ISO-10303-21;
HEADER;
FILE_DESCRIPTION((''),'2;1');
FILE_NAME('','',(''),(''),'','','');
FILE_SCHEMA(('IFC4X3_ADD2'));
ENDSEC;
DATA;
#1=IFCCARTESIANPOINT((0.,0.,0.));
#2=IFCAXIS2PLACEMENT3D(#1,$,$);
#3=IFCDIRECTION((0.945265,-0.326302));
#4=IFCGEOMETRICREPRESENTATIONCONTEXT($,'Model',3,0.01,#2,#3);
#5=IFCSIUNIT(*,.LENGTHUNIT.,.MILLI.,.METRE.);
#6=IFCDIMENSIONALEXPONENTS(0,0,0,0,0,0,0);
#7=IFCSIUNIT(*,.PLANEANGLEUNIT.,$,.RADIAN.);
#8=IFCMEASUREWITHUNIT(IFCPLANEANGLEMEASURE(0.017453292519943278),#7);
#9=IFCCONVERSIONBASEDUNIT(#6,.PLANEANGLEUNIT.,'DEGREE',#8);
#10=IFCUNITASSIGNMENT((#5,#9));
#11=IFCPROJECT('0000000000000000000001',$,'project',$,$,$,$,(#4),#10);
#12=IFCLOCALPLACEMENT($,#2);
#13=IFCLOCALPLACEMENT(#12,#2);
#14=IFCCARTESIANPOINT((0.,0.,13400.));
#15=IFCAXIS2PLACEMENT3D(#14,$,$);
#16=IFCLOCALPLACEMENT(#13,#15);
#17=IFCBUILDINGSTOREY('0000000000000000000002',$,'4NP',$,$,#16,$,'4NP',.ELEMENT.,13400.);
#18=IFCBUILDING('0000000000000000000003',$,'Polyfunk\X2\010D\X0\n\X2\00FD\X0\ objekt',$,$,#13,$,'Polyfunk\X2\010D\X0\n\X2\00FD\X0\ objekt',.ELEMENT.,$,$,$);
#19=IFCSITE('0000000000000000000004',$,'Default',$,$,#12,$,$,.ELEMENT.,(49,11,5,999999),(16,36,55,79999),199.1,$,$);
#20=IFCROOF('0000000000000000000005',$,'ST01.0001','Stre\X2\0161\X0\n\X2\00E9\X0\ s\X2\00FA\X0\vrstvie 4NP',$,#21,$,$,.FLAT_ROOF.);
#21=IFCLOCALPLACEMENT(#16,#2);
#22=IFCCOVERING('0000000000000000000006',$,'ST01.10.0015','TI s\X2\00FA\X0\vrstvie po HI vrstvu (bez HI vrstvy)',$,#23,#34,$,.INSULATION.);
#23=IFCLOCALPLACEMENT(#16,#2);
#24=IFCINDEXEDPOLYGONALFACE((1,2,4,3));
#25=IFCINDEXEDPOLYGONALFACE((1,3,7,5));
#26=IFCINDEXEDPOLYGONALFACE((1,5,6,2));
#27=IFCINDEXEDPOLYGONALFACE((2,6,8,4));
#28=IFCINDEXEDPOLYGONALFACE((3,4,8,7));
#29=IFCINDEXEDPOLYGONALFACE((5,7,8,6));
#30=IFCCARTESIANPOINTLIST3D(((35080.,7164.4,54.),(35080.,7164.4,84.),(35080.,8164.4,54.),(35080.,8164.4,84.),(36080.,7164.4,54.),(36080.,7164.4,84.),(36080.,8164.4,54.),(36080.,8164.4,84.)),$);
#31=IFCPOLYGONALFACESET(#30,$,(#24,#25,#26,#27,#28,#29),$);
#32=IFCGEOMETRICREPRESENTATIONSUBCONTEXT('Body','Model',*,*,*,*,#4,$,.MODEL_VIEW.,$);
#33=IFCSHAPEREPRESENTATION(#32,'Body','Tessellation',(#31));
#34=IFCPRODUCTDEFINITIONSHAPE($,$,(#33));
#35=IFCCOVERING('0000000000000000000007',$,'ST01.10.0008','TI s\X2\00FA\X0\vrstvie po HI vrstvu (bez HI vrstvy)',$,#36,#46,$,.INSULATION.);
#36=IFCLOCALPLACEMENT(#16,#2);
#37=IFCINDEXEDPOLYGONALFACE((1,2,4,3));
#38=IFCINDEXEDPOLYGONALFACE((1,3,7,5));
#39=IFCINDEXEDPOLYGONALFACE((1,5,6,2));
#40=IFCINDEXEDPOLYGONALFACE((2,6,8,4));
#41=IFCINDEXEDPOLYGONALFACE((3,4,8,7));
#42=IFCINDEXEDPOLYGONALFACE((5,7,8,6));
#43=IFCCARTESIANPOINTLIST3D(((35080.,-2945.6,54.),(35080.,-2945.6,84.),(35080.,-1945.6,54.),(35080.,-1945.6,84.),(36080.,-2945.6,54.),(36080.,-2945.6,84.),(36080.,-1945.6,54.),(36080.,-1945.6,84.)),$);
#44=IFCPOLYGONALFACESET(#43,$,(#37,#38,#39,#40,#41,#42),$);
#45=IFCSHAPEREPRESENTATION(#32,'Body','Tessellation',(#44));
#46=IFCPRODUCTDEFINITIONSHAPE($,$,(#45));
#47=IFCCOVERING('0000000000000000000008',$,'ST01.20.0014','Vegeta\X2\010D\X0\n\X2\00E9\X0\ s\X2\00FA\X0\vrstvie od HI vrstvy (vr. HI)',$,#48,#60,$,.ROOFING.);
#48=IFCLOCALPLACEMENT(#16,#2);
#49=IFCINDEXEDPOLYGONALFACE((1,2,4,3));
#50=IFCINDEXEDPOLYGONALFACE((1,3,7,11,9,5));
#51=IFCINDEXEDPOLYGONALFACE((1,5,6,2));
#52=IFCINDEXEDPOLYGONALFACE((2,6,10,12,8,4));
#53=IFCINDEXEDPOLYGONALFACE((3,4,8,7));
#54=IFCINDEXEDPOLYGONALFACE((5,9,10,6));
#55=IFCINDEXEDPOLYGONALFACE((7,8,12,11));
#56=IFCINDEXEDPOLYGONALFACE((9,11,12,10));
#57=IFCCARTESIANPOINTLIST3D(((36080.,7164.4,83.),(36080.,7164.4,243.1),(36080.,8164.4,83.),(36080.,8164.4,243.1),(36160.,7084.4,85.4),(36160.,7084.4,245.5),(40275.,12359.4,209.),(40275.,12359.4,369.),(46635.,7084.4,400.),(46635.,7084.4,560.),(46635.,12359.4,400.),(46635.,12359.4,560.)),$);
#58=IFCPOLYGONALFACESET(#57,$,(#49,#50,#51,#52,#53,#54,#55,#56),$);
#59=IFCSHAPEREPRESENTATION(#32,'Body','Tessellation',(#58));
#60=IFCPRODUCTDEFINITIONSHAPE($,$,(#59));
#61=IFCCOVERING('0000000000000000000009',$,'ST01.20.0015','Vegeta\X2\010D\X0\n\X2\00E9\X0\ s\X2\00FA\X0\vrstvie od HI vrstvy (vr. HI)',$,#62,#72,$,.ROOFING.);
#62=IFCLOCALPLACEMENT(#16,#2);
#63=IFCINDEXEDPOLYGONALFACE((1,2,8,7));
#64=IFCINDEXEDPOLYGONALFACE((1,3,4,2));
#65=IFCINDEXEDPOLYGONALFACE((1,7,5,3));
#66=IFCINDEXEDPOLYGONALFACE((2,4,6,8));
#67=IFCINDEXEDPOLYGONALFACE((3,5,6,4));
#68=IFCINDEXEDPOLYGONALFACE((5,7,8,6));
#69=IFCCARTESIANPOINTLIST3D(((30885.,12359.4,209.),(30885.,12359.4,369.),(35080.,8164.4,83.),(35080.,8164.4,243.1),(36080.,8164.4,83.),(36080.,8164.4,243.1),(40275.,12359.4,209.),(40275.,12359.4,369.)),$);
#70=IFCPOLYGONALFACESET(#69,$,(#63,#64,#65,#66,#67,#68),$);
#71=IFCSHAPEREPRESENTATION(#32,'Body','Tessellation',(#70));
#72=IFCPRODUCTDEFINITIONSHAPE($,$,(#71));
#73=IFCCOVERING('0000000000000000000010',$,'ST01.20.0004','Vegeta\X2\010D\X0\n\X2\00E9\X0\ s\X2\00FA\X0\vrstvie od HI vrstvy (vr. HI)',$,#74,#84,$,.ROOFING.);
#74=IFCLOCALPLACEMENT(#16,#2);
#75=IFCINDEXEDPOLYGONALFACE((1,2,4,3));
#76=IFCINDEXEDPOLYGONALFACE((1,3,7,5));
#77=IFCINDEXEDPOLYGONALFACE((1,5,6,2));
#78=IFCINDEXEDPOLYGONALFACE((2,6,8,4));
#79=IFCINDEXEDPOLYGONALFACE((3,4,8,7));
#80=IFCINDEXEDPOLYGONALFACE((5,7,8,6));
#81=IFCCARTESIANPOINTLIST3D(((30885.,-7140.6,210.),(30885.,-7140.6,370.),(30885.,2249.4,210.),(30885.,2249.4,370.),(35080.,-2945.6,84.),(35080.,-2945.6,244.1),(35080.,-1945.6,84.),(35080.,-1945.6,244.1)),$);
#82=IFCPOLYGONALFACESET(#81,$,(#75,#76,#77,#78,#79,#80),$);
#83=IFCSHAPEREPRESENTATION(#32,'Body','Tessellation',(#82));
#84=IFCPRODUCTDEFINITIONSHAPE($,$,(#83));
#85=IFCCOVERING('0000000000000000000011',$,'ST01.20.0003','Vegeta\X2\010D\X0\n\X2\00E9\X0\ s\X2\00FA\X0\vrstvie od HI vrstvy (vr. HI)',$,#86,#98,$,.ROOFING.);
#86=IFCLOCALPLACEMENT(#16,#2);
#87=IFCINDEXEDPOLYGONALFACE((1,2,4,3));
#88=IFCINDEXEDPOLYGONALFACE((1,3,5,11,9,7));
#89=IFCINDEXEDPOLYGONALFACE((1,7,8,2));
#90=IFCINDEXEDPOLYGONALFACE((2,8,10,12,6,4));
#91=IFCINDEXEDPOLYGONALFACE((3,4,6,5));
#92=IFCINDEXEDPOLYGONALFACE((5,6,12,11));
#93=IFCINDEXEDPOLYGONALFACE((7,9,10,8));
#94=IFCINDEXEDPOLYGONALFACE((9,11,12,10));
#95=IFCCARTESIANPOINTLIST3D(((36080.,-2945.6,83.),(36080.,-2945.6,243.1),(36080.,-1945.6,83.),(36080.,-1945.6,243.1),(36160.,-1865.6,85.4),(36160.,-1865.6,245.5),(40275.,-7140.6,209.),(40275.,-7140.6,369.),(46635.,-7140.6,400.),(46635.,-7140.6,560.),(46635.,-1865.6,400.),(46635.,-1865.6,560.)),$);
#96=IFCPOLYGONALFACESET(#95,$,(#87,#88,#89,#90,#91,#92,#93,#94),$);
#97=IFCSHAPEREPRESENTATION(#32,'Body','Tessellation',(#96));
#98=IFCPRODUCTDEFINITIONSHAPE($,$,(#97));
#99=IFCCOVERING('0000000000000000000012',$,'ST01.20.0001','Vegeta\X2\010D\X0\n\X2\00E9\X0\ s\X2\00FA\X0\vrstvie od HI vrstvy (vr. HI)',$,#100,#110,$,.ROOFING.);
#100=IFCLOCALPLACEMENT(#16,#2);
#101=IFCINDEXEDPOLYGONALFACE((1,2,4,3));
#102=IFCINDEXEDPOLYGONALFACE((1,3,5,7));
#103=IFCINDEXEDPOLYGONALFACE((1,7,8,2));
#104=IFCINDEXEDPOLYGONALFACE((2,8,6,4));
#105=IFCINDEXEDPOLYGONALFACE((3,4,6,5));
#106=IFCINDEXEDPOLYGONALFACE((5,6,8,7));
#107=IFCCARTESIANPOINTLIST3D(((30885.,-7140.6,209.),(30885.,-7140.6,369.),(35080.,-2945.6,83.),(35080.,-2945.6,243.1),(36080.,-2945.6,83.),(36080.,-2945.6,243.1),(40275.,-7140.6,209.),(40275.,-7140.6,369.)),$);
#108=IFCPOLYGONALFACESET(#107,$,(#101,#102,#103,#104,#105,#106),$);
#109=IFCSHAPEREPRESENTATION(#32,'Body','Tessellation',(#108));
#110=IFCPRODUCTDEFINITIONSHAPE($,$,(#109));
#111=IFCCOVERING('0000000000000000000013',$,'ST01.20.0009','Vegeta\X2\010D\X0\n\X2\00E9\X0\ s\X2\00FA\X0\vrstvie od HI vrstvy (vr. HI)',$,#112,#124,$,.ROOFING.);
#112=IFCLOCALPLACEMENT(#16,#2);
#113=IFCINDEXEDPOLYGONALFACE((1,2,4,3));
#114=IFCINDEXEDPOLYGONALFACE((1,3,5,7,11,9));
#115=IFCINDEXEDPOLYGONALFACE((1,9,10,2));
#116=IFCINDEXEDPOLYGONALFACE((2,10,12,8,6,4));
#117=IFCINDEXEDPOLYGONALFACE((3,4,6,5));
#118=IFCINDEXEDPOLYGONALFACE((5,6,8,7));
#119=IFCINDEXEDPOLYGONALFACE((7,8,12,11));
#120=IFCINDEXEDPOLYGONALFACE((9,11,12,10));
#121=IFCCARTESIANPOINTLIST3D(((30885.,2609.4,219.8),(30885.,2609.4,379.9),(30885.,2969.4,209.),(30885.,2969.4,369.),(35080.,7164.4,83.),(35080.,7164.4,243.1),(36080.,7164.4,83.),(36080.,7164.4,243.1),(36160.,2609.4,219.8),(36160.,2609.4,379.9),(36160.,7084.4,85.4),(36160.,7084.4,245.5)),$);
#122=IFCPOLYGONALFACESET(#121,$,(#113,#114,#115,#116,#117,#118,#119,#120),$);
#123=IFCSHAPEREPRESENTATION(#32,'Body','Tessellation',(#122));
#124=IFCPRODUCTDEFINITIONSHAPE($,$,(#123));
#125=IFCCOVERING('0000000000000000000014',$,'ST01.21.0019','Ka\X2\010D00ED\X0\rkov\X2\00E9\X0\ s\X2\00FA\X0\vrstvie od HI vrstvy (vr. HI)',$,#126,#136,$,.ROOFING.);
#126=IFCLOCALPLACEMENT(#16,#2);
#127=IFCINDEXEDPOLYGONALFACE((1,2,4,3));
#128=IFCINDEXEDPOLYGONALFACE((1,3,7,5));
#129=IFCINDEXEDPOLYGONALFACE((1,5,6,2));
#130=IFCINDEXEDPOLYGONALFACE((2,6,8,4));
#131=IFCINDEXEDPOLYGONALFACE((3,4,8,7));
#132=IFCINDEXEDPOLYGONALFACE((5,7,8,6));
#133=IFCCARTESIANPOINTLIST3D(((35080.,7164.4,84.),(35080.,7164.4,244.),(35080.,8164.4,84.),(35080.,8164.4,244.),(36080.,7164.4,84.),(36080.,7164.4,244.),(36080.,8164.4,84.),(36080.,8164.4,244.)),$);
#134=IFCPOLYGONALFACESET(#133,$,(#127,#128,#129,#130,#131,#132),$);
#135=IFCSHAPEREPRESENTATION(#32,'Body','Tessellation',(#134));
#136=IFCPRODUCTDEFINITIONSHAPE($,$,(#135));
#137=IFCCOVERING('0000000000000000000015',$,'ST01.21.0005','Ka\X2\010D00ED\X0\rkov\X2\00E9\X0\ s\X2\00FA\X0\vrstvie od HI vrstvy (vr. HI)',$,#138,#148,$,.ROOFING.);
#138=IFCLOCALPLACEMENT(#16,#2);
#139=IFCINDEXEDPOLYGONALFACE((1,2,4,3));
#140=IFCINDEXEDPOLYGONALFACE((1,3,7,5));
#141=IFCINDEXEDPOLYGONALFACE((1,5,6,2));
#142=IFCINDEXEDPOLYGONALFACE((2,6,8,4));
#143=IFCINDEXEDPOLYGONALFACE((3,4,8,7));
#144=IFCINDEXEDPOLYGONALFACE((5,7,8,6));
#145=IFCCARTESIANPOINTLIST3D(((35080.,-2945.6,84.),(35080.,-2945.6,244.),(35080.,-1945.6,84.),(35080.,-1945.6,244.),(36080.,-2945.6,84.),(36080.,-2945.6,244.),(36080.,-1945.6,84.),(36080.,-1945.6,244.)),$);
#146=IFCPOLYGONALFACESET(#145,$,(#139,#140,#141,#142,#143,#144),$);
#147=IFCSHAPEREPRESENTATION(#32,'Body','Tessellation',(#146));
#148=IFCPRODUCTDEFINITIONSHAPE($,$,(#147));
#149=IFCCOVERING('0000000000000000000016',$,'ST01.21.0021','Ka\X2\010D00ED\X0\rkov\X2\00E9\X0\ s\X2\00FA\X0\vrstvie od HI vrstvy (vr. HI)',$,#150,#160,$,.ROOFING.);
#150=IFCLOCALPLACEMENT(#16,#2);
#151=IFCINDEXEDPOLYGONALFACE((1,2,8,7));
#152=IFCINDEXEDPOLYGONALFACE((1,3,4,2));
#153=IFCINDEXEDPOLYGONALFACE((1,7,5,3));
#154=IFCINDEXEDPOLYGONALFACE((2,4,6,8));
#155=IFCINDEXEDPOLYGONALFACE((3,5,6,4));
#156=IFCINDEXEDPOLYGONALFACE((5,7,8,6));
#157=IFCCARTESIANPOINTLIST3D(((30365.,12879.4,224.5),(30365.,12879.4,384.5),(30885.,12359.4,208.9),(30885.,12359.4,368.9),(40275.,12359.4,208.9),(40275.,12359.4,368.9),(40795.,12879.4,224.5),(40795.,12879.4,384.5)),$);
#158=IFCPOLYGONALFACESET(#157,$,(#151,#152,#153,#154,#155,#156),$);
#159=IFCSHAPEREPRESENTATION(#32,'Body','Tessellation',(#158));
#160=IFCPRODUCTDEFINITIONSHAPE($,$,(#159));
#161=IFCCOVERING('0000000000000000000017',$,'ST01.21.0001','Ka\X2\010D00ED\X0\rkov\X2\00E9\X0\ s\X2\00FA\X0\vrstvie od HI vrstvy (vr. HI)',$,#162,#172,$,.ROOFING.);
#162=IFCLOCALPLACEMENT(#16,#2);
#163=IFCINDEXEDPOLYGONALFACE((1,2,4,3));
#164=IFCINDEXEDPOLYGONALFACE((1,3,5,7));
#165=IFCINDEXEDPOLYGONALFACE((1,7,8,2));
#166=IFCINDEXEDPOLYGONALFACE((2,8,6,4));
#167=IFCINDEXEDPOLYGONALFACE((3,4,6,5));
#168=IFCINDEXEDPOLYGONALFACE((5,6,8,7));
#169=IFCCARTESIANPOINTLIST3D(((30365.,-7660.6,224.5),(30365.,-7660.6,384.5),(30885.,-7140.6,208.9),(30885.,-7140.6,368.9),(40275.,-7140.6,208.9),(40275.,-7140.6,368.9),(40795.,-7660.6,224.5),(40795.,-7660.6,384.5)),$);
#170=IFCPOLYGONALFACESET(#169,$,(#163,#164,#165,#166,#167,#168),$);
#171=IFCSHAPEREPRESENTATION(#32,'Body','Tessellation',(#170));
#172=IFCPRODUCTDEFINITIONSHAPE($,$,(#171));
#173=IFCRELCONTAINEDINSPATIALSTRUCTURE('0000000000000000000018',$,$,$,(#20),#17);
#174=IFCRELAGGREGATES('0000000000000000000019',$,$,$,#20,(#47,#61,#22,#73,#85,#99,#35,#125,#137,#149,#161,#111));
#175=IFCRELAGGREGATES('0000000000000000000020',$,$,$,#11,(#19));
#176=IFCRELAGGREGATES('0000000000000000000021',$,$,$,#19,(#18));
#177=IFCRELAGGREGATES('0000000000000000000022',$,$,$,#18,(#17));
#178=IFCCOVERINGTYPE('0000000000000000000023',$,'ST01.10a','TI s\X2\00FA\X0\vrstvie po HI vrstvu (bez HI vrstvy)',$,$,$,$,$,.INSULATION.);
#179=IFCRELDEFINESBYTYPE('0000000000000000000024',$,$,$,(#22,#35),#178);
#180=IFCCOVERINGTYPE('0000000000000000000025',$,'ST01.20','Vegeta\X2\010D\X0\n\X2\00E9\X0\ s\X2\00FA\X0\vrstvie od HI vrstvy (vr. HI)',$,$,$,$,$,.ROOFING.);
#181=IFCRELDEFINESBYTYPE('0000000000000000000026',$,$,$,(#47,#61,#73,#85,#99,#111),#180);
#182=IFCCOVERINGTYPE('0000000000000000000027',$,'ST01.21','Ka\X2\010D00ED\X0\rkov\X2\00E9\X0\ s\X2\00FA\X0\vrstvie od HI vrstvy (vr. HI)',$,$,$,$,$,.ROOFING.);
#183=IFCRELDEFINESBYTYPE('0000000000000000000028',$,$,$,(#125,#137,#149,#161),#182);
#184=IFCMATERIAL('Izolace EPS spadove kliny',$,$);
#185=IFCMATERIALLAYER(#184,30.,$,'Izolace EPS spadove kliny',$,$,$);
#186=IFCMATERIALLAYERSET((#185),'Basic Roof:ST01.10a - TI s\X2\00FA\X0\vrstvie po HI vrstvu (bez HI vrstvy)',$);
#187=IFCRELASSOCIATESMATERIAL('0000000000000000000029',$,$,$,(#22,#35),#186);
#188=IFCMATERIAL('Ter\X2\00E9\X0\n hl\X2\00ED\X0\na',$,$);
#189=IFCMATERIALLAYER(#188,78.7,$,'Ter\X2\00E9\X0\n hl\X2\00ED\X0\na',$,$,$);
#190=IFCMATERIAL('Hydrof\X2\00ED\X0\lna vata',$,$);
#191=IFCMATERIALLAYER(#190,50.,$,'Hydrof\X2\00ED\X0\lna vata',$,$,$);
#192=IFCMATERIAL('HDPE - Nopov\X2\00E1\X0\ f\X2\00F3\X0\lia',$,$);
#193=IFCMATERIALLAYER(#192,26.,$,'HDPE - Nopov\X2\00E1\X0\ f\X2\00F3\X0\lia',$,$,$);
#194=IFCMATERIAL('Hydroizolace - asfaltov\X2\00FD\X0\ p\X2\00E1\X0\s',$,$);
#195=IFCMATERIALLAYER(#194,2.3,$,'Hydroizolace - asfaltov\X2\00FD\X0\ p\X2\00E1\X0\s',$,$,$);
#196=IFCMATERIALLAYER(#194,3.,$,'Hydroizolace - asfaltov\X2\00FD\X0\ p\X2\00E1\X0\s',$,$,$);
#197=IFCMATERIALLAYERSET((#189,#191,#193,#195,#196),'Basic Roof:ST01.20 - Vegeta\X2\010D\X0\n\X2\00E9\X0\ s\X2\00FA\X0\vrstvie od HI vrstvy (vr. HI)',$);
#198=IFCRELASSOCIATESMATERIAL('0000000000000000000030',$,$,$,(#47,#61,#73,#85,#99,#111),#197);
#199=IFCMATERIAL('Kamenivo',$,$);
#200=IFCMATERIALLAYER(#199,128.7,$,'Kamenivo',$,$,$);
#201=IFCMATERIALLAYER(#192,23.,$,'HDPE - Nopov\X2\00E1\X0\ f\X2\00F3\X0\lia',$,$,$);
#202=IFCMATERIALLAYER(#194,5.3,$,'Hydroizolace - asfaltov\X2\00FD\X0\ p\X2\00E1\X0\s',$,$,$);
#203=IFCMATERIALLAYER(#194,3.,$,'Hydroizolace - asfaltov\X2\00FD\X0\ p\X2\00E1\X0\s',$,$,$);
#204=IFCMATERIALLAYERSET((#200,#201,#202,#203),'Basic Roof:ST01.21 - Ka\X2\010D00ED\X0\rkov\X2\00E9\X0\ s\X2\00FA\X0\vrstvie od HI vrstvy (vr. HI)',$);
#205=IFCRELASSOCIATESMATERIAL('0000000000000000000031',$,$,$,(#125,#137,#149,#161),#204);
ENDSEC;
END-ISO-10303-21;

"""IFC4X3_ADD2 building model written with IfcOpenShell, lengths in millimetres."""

from ifc_helpers import new_model, entity, si_unit, converted_unit, direction, frame, frame_2d, origin, origin_2d_with_axis, place, context, subcontext, project, spatial, polyline, rectangle, outline, extrude, material, layer, layer_set, type_object, element, aggregate, save


model = new_model("IFC4X3_ADD2")

# Units and contexts
model_context = context("Model", 3, precision=0.01, world=origin(), true_north=direction((0.945265, -0.326302)))
body_context = subcontext(model_context, "Body", "Model", "MODEL_VIEW")
ifc_project = project(units=[si_unit("LENGTHUNIT", "METRE", prefix="MILLI"), converted_unit("PLANEANGLEUNIT", "DEGREE", entity("IfcPlaneAngleMeasure", 0.017453292519943278), si_unit("PLANEANGLEUNIT", "RADIAN"), dimensions=[0, 0, 0, 0, 0, 0, 0])], contexts=[model_context])

# Site, building, storey
site_placement = place(None, origin())
site = spatial("IfcSite", under=ifc_project, at=site_placement, Name="Default", CompositionType="ELEMENT", RefLatitude=(49, 11, 5, 999999), RefLongitude=(16, 36, 55, 79999), RefElevation=199.1)
building_placement = place(site_placement, origin())
building = spatial("IfcBuilding", under=site, at=building_placement, Name="Polyfunkčný objekt", LongName="Polyfunkčný objekt", CompositionType="ELEMENT")
storey_placement = place(building_placement, frame((0.0, 0.0, 13400.0)))
storey = spatial("IfcBuildingStorey", under=building, at=storey_placement, Name="4NP", LongName="4NP", CompositionType="ELEMENT", Elevation=13400.0)

# Roof, coverings
roof = element("IfcRoof", 1, inside=storey, Name="ST01.0001", Description="Strešné súvrstvie 4NP", PredefinedType="FLAT_ROOF")
ifc_material_1 = material(Name="Hydroizolace - asfaltový pás")
ifc_material_2 = material(Name="Izolace EPS spadove kliny")
ifc_layer_1 = layer(ifc_material_2, 30.0, Name="Izolace EPS spadove kliny")
ifc_layer_set_1 = layer_set([ifc_layer_1], Name="Basic Roof:ST01.10a - TI súvrstvie po HI vrstvu (bez HI vrstvy)")
covering_type_1 = type_object("IfcCoveringType", Name="ST01.10a", Description="TI súvrstvie po HI vrstvu (bez HI vrstvy)", PredefinedType="INSULATION")
placement_1 = place(storey_placement, frame((35080.0, 7164.4, 54.0)))
covering_1_placement = place(placement_1, origin())
covering_1 = element("IfcCovering", 2, at=covering_1_placement, type_object=covering_type_1, material=ifc_layer_set_1, Name="ST01.10.0015", Description="TI súvrstvie po HI vrstvu (bez HI vrstvy)", PredefinedType="INSULATION", context=body_context, shape_type="SweptSolid", body=[
    extrude(rectangle(XDim=1000.0, YDim=1000.0, at=frame_2d((0.0, 0.0), x_axis=(1.0, 0.0))), frame((500.0, 500.0, 0.0)), (0.0, 0.0, 1.0), 30.0),
])
covering_2_placement = place(storey_placement, frame((35080.0, -2945.6, 54.0)))
covering_2 = element("IfcCovering", 3, at=covering_2_placement, type_object=covering_type_1, material=ifc_layer_set_1, Name="ST01.10.0008", Description="TI súvrstvie po HI vrstvu (bez HI vrstvy)", PredefinedType="INSULATION", context=body_context, shape_type="SweptSolid", body=[
    extrude(rectangle(XDim=1000.0, YDim=1000.0, at=frame_2d((0.0, 0.0), x_axis=(1.0, 0.0))), frame((500.0, 500.0, 0.0), z_axis=(0.0, 0.0, 1.0), x_axis=(0.0, 1.0, 0.0)), (0.0, 0.0, 1.0), 30.0),
])
ifc_material_3 = material(Name="Terén hlína")
ifc_layer_2 = layer(ifc_material_3, 78.7, Name="Terén hlína")
ifc_material_4 = material(Name="Hydrofílna vata")
ifc_layer_3 = layer(ifc_material_4, 50.0, Name="Hydrofílna vata")
ifc_material_5 = material(Name="HDPE - Nopová fólia")
ifc_layer_4 = layer(ifc_material_5, 26.0, Name="HDPE - Nopová fólia")
ifc_layer_5 = layer(ifc_material_1, 2.3, Name="Hydroizolace - asfaltový pás")
ifc_layer_6 = layer(ifc_material_1, 3.0, Name="Hydroizolace - asfaltový pás")
ifc_layer_set_2 = layer_set([ifc_layer_2, ifc_layer_3, ifc_layer_4, ifc_layer_5, ifc_layer_6], Name="Basic Roof:ST01.20 - Vegetačné súvrstvie od HI vrstvy (vr. HI)")
covering_type_2 = type_object("IfcCoveringType", Name="ST01.20", Description="Vegetačné súvrstvie od HI vrstvy (vr. HI)", PredefinedType="ROOFING")
placement_2 = place(storey_placement, frame((36080.0, 7084.4, 83.0)))
covering_3_placement = place(placement_2, origin())
covering_3 = element("IfcCovering", 4, at=covering_3_placement, type_object=covering_type_2, material=ifc_layer_set_2, Name="ST01.20.0014", Description="Vegetačné súvrstvie od HI vrstvy (vr. HI)", PredefinedType="ROOFING", context=body_context, shape_type="SweptSolid", body=[
    extrude(outline(polyline([(-5279.9, -2557.5), (-5199.8, -2637.5), (5279.9, -2637.5), (5279.9, 2637.5), (-1083.0, 2637.5), (-5279.9, -1557.5), (-5279.9, -2557.5)])), frame((5277.5, 2637.5, 158.5), z_axis=(-0.030015, 0.0, 0.999549), x_axis=(0.999549, 0.0, 0.030015)), (0.030015, 0.0, 0.999549), 160.1),
])
placement_3 = place(storey_placement, frame((30885.0, 8164.4, 83.0)))
covering_4_placement = place(placement_3, origin())
covering_4 = element("IfcCovering", 5, at=covering_4_placement, type_object=covering_type_2, material=ifc_layer_set_2, Name="ST01.20.0015", Description="Vegetačné súvrstvie od HI vrstvy (vr. HI)", PredefinedType="ROOFING", context=body_context, shape_type="SweptSolid", body=[
    extrude(outline(polyline([(500.0, -2098.4), (4695.0, 2098.4), (-4695.0, 2098.4), (-500.0, -2098.4), (500.0, -2098.4)])), frame((4695.0, 2097.5, 63.0), z_axis=(0.0, -0.030015, 0.999549), x_axis=(1.0, 0.0, 0.0)), (0.0, 0.030015, 0.999549), 160.1),
])
placement_4 = place(storey_placement, frame((30885.0, -7140.6, 84.0)))
covering_5_placement = place(placement_4, origin())
covering_5 = element("IfcCovering", 6, at=covering_5_placement, type_object=covering_type_2, material=ifc_layer_set_2, Name="ST01.20.0004", Description="Vegetačné súvrstvie od HI vrstvy (vr. HI)", PredefinedType="ROOFING", context=body_context, shape_type="SweptSolid", body=[
    extrude(outline(polyline([(2098.4, 500.0), (-2098.4, 4695.0), (-2098.4, -4695.0), (2098.4, -500.0), (2098.4, 500.0)])), frame((2097.5, 4695.0, 63.0), z_axis=(0.030015, 0.0, 0.999549), x_axis=(0.999549, 0.0, -0.030015)), (-0.030015, 0.0, 0.999549), 160.1),
])
placement_5 = place(storey_placement, frame((36080.0, -7140.6, 83.0)))
covering_6_placement = place(placement_5, origin())
covering_6 = element("IfcCovering", 7, at=covering_6_placement, type_object=covering_type_2, material=ifc_layer_set_2, Name="ST01.20.0003", Description="Vegetačné súvrstvie od HI vrstvy (vr. HI)", PredefinedType="ROOFING", context=body_context, shape_type="SweptSolid", body=[
    extrude(outline(polyline([(-5279.9, 1557.5), (-1083.0, -2637.5), (5279.9, -2637.5), (5279.9, 2637.5), (-5199.8, 2637.5), (-5279.9, 2557.5), (-5279.9, 1557.5)])), frame((5277.5, 2637.5, 158.5), z_axis=(-0.030015, 0.0, 0.999549), x_axis=(0.999549, 0.0, 0.030015)), (0.030015, 0.0, 0.999549), 160.1),
])
placement_6 = place(storey_placement, frame((30885.0, -7140.6, 83.0)))
covering_7_placement = place(placement_6, origin())
covering_7 = element("IfcCovering", 8, at=covering_7_placement, type_object=covering_type_2, material=ifc_layer_set_2, Name="ST01.20.0001", Description="Vegetačné súvrstvie od HI vrstvy (vr. HI)", PredefinedType="ROOFING", context=body_context, shape_type="SweptSolid", body=[
    extrude(outline(polyline([(-500.0, 2098.4), (-4695.0, -2098.4), (4695.0, -2098.4), (500.0, 2098.4), (-500.0, 2098.4)])), frame((4695.0, 2097.5, 63.0), z_axis=(0.0, 0.030015, 0.999549), x_axis=(1.0, 0.0, 0.0)), (0.0, -0.030015, 0.999549), 160.1),
])
placement_7 = place(storey_placement, frame((30885.0, 2609.4, 83.0)))
covering_8_placement = place(placement_7, origin())
covering_8 = element("IfcCovering", 9, at=covering_8_placement, type_object=covering_type_2, material=ifc_layer_set_2, Name="ST01.20.0009", Description="Vegetačné súvrstvie od HI vrstvy (vr. HI)", PredefinedType="ROOFING", context=body_context, shape_type="SweptSolid", body=[
    extrude(outline(polyline([(1557.5, 2278.5), (-2637.5, -1918.4), (-2637.5, -2278.5), (2637.5, -2278.5), (2637.5, 2198.5), (2557.5, 2278.5), (1557.5, 2278.5)])), frame((2637.5, 2277.5, 68.4), z_axis=(0.0, 0.030015, 0.999549), x_axis=(1.0, 0.0, 0.0)), (0.0, -0.030015, 0.999549), 160.1),
])
ifc_material_6 = material(Name="Kamenivo")
ifc_layer_7 = layer(ifc_material_6, 128.7, Name="Kamenivo")
ifc_layer_8 = layer(ifc_material_5, 23.0, Name="HDPE - Nopová fólia")
ifc_layer_9 = layer(ifc_material_1, 5.3, Name="Hydroizolace - asfaltový pás")
ifc_layer_10 = layer(ifc_material_1, 3.0, Name="Hydroizolace - asfaltový pás")
ifc_layer_set_3 = layer_set([ifc_layer_7, ifc_layer_8, ifc_layer_9, ifc_layer_10], Name="Basic Roof:ST01.21 - Kačírkové súvrstvie od HI vrstvy (vr. HI)")
covering_type_3 = type_object("IfcCoveringType", Name="ST01.21", Description="Kačírkové súvrstvie od HI vrstvy (vr. HI)", PredefinedType="ROOFING")
placement_8 = place(storey_placement, frame((35080.0, 7164.4, 84.0)))
covering_9_placement = place(placement_8, origin())
covering_9 = element("IfcCovering", 10, at=covering_9_placement, type_object=covering_type_3, material=ifc_layer_set_3, Name="ST01.21.0019", Description="Kačírkové súvrstvie od HI vrstvy (vr. HI)", PredefinedType="ROOFING", context=body_context, shape_type="SweptSolid", body=[
    extrude(rectangle(XDim=1000.0, YDim=1000.0, at=frame_2d((0.0, 0.0), x_axis=(1.0, 0.0))), frame((500.0, 500.0, 0.0)), (0.0, 0.0, 1.0), 160.0),
])
covering_10_placement = place(storey_placement, frame((35080.0, -2945.6, 84.0)))
covering_10 = element("IfcCovering", 11, at=covering_10_placement, type_object=covering_type_3, material=ifc_layer_set_3, Name="ST01.21.0005", Description="Kačírkové súvrstvie od HI vrstvy (vr. HI)", PredefinedType="ROOFING", context=body_context, shape_type="SweptSolid", body=[
    extrude(rectangle(XDim=1000.0, YDim=1000.0, at=origin_2d_with_axis()), frame((500.0, 500.0, 0.0), z_axis=(0.0, 0.0, 1.0), x_axis=(0.0, -1.0, 0.0)), (0.0, 0.0, 1.0), 160.0),
])
placement_9 = place(storey_placement, frame((30365.0, 12359.4, 208.9)))
covering_11_placement = place(placement_9, origin())
covering_11 = element("IfcCovering", 12, at=covering_11_placement, type_object=covering_type_3, material=ifc_layer_set_3, Name="ST01.21.0021", Description="Kačírkové súvrstvie od HI vrstvy (vr. HI)", PredefinedType="ROOFING", context=body_context, shape_type="SweptSolid", body=[
    extrude(outline(polyline([(4695.0, -260.1), (5215.0, 260.1), (-5215.0, 260.1), (-4695.0, -260.1), (4695.0, -260.1)])), frame((5215.0, 260.0, 7.8), z_axis=(0.0, -0.030015, 0.999549), x_axis=(1.0, 0.0, 0.0)), (0.0, 0.030015, 0.999549), 160.1),
])
placement_10 = place(storey_placement, frame((30365.0, -7660.6, 208.9)))
covering_12_placement = place(placement_10, origin())
covering_12 = element("IfcCovering", 13, at=covering_12_placement, type_object=covering_type_3, material=ifc_layer_set_3, Name="ST01.21.0001", Description="Kačírkové súvrstvie od HI vrstvy (vr. HI)", PredefinedType="ROOFING", context=body_context, shape_type="SweptSolid", body=[
    extrude(outline(polyline([(-4695.0, 260.1), (-5215.0, -260.1), (5215.0, -260.1), (4695.0, 260.1), (-4695.0, 260.1)])), frame((5215.0, 260.0, 7.8), z_axis=(0.0, 0.030015, 0.999549), x_axis=(1.0, 0.0, 0.0)), (0.0, -0.030015, 0.999549), 160.1),
])
aggregate(roof, [covering_3, covering_4, covering_1, covering_5, covering_6, covering_7, covering_2, covering_9, covering_10, covering_11, covering_12, covering_8])

save(model, "model.ifc")
